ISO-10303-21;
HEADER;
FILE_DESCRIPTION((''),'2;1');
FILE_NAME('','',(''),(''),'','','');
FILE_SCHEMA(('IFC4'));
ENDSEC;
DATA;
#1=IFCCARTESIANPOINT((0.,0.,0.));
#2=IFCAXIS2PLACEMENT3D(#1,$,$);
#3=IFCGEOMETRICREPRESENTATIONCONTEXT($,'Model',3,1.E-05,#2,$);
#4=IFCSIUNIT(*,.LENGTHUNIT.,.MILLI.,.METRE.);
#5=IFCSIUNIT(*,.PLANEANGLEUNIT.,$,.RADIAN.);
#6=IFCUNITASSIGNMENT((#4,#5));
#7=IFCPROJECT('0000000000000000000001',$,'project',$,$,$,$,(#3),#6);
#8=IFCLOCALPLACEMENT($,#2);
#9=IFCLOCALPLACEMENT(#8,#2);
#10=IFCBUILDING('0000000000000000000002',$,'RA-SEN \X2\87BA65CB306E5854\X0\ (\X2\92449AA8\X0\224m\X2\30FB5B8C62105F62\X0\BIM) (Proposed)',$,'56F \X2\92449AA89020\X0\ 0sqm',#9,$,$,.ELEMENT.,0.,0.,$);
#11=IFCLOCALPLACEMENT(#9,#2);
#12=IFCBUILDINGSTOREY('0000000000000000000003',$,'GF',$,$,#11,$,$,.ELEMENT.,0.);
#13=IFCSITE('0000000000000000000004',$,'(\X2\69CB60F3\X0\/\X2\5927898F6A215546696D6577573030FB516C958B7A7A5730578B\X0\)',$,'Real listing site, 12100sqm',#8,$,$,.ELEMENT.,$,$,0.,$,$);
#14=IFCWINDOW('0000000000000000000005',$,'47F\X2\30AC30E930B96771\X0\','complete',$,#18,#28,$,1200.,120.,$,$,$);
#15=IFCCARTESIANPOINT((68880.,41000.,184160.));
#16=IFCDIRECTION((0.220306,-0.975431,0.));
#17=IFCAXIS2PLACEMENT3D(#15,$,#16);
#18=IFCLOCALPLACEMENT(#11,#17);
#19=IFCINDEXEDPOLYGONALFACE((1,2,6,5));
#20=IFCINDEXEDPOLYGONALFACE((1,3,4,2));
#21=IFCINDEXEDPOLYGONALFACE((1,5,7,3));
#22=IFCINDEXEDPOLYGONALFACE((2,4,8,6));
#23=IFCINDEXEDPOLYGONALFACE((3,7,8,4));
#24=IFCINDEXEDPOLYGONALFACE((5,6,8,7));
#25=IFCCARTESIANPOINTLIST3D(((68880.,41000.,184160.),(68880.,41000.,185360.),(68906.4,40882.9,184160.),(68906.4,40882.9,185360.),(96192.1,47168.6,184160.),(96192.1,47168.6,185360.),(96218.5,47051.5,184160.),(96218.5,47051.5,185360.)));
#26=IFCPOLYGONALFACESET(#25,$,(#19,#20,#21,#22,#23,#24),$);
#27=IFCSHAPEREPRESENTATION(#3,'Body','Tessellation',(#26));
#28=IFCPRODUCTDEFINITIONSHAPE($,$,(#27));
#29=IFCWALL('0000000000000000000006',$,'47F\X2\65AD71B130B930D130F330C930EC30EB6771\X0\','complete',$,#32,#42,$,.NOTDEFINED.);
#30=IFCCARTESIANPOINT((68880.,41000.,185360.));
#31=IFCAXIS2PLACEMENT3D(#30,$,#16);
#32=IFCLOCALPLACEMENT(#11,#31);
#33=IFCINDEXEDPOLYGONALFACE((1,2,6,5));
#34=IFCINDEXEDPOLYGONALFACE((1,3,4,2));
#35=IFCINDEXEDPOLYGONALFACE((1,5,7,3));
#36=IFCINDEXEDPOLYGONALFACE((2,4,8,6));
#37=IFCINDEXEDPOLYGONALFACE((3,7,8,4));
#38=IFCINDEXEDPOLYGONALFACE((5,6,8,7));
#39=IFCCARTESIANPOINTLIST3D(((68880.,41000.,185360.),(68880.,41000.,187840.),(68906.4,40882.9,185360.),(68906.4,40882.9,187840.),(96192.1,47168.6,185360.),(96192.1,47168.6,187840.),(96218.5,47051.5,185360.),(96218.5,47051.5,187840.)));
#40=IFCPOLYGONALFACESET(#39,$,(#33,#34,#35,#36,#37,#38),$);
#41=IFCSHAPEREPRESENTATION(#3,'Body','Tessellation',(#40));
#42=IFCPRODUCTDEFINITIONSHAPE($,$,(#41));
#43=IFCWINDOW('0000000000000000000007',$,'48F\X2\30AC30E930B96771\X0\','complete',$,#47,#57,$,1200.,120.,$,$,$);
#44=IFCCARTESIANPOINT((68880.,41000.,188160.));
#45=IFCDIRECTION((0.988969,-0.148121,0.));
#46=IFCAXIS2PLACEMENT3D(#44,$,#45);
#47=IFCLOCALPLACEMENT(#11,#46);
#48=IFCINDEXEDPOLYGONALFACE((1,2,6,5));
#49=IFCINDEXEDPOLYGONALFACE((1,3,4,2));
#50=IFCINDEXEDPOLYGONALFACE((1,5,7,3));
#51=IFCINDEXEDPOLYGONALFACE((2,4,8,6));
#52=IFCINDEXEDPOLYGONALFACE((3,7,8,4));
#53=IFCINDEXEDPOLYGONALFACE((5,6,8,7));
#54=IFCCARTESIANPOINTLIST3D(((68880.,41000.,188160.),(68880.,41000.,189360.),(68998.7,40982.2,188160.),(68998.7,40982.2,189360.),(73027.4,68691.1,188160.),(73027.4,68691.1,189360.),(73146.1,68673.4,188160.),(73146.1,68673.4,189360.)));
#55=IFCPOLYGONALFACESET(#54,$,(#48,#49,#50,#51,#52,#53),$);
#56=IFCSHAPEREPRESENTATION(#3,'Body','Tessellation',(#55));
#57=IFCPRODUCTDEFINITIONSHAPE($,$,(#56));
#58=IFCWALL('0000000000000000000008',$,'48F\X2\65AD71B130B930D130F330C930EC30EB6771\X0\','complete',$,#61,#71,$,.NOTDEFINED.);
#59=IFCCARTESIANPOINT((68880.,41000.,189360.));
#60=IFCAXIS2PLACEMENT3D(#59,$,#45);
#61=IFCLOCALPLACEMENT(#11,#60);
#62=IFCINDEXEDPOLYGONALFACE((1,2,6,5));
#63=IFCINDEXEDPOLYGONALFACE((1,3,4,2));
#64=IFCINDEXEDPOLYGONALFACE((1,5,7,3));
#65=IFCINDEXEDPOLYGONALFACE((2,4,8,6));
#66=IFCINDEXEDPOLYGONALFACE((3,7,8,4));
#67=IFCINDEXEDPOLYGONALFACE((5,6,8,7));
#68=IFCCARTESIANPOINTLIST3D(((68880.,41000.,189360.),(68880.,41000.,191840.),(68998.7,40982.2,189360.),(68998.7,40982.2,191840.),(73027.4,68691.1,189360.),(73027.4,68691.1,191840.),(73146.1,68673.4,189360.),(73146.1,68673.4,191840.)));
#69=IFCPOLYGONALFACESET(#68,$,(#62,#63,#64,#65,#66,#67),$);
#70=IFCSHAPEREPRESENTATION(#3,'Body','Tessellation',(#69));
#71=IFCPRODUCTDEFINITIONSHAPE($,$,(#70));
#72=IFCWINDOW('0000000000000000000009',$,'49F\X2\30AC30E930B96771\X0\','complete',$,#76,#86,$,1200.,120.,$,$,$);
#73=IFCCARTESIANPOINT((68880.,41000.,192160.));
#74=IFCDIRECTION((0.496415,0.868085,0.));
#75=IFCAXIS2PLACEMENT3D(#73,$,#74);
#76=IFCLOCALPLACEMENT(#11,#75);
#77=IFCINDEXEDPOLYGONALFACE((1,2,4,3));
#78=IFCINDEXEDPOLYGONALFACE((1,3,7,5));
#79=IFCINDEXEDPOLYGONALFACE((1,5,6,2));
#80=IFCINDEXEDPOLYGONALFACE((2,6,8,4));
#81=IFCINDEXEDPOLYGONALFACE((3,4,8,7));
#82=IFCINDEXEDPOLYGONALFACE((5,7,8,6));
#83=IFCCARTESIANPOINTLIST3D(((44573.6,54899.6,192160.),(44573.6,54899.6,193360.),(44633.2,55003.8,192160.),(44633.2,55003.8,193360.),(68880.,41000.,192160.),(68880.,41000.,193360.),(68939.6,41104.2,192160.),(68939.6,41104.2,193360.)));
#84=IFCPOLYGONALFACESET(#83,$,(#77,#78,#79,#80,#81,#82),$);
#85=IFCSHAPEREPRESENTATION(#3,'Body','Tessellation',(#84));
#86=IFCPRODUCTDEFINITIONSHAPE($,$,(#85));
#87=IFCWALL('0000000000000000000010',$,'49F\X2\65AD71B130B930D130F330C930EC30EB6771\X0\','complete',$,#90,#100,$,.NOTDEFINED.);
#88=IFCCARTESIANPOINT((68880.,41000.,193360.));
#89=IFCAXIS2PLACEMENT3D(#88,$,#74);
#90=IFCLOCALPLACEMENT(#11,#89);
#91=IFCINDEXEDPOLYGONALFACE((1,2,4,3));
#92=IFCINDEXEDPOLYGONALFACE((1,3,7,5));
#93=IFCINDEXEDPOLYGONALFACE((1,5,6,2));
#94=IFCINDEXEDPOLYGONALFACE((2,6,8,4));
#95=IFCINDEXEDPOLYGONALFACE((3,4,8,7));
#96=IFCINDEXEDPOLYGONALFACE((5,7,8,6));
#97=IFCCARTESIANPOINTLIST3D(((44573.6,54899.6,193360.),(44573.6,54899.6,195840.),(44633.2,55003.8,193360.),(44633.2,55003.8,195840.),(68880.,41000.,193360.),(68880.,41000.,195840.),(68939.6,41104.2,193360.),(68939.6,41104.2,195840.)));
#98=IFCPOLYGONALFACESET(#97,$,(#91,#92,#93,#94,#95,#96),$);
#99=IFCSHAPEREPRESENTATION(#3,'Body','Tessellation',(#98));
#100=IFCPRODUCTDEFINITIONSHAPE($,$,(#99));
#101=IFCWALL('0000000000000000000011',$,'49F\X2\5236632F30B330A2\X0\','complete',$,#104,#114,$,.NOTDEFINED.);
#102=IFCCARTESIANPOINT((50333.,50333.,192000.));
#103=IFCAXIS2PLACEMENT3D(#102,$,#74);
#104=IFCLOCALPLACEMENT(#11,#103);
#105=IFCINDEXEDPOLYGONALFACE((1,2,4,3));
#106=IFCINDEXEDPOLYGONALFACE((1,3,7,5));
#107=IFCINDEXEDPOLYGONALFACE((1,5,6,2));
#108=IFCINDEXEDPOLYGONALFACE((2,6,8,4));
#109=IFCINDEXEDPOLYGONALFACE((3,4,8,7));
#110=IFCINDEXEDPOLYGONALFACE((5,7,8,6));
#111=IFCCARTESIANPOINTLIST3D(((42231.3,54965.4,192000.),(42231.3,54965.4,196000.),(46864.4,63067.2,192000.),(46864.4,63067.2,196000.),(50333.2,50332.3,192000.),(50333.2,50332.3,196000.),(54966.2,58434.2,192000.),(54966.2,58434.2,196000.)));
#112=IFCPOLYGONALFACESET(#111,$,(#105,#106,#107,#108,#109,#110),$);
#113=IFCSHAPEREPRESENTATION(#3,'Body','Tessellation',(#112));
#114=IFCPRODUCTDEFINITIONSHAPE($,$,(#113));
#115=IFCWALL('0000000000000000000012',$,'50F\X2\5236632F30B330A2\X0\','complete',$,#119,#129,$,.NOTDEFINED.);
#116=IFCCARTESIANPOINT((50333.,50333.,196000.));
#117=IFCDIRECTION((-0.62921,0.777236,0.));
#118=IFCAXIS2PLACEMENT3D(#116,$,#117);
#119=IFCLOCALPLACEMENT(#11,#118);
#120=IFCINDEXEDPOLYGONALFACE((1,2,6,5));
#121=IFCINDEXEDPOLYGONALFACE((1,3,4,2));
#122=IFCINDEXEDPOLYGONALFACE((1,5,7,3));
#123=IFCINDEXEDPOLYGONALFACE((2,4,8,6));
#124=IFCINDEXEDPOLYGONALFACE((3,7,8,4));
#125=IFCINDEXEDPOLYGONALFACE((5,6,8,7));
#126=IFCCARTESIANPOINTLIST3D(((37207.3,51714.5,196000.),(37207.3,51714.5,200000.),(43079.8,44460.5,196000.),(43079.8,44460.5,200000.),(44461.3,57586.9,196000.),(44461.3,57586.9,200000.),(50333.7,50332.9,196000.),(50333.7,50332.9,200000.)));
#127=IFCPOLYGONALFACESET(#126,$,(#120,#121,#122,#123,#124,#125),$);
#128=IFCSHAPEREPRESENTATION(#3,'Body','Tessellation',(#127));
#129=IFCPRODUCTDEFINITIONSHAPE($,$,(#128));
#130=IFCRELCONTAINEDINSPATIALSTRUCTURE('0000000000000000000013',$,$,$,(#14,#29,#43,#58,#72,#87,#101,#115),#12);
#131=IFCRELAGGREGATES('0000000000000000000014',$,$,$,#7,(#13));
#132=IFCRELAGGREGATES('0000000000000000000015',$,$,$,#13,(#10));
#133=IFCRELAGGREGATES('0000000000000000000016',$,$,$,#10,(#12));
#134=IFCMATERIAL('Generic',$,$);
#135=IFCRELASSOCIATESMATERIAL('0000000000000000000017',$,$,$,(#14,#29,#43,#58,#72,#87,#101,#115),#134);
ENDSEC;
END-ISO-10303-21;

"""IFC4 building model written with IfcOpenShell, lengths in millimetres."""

from ifc_helpers import new_model, si_unit, frame, frame_2d, origin, place, context, project, spatial, rectangle, extrude, material, element, save


model = new_model("IFC4")

# Units and contexts
model_context = context("Model", 3, precision=1e-05, world=origin())
ifc_project = project(units=[si_unit("LENGTHUNIT", "METRE", prefix="MILLI"), si_unit("PLANEANGLEUNIT", "RADIAN")], contexts=[model_context])

# Site, building, storey
site_placement = place(None, origin())
site = spatial("IfcSite", under=ifc_project, at=site_placement, Name="(構想/大規模商業敷地・公開空地型)", ObjectType="Real listing site, 12100sqm", CompositionType="ELEMENT", RefElevation=0.0)
building_placement = place(site_placement, origin())
building = spatial("IfcBuilding", under=site, at=building_placement, Name="RA-SEN 螺旋の塔 (鉄骨224m・完成形BIM) (Proposed)", ObjectType="56F 鉄骨造 0sqm", CompositionType="ELEMENT", ElevationOfRefHeight=0.0, ElevationOfTerrain=0.0)
storey_placement = place(building_placement, origin())
storey = spatial("IfcBuildingStorey", under=building, at=storey_placement, Name="GF", CompositionType="ELEMENT", Elevation=0.0)

# Shared definitions
ifc_material = material(Name="Generic")

# Window
window_1_placement = place(storey_placement, frame((68880.0, 41000.0, 184160.0), x_axis=(0.220306, -0.975431, 0.0)))
element("IfcWindow", 1, at=window_1_placement, inside=storey, material=ifc_material, Name="47Fガラス東", Description="complete", OverallHeight=1200.0, OverallWidth=120.0, context=model_context, shape_type="SweptSolid", body=[
    extrude(rectangle(XDim=120.0, YDim=28000.0, at=frame_2d((60.0, 14000.0))), frame((68880.0, 41000.0, 184160.0), x_axis=(0.220306, -0.975431, 0.0)), (0.0, 0.0, 1.0), 1200.0),
])

# Wall
wall_1_placement = place(storey_placement, frame((68880.0, 41000.0, 185360.0), x_axis=(0.220306, -0.975431, 0.0)))
element("IfcWall", 2, at=wall_1_placement, inside=storey, material=ifc_material, Name="47F断熱スパンドレル東", Description="complete", PredefinedType="NOTDEFINED", context=model_context, shape_type="SweptSolid", body=[
    extrude(rectangle(XDim=120.0, YDim=28000.0, at=frame_2d((60.0, 14000.0))), frame((68880.0, 41000.0, 185360.0), x_axis=(0.220306, -0.975431, 0.0)), (0.0, 0.0, 1.0), 2480.0),
])

# Window
window_2_placement = place(storey_placement, frame((68880.0, 41000.0, 188160.0), x_axis=(0.988969, -0.148121, 0.0)))
element("IfcWindow", 3, at=window_2_placement, inside=storey, material=ifc_material, Name="48Fガラス東", Description="complete", OverallHeight=1200.0, OverallWidth=120.0, context=model_context, shape_type="SweptSolid", body=[
    extrude(rectangle(XDim=120.0, YDim=28000.0, at=frame_2d((60.0, 14000.0))), frame((68880.0, 41000.0, 188160.0), x_axis=(0.988969, -0.148121, 0.0)), (0.0, 0.0, 1.0), 1200.0),
])

# Wall
wall_2_placement = place(storey_placement, frame((68880.0, 41000.0, 189360.0), x_axis=(0.988969, -0.148121, 0.0)))
element("IfcWall", 4, at=wall_2_placement, inside=storey, material=ifc_material, Name="48F断熱スパンドレル東", Description="complete", PredefinedType="NOTDEFINED", context=model_context, shape_type="SweptSolid", body=[
    extrude(rectangle(XDim=120.0, YDim=28000.0, at=frame_2d((60.0, 14000.0))), frame((68880.0, 41000.0, 189360.0), x_axis=(0.988969, -0.148121, 0.0)), (0.0, 0.0, 1.0), 2480.0),
])

# Window
window_3_placement = place(storey_placement, frame((68880.0, 41000.0, 192160.0), x_axis=(0.496415, 0.868085, 0.0)))
element("IfcWindow", 5, at=window_3_placement, inside=storey, material=ifc_material, Name="49Fガラス東", Description="complete", OverallHeight=1200.0, OverallWidth=120.0, context=model_context, shape_type="SweptSolid", body=[
    extrude(rectangle(XDim=120.0, YDim=28000.0, at=frame_2d((60.0, 14000.0))), frame((68880.0, 41000.0, 192160.0), x_axis=(0.496415, 0.868085, 0.0)), (0.0, 0.0, 1.0), 1200.0),
])

# Walls
wall_3_placement = place(storey_placement, frame((68880.0, 41000.0, 193360.0), x_axis=(0.496415, 0.868085, 0.0)))
element("IfcWall", 6, at=wall_3_placement, inside=storey, material=ifc_material, Name="49F断熱スパンドレル東", Description="complete", PredefinedType="NOTDEFINED", context=model_context, shape_type="SweptSolid", body=[
    extrude(rectangle(XDim=120.0, YDim=28000.0, at=frame_2d((60.0, 14000.0))), frame((68880.0, 41000.0, 193360.0), x_axis=(0.496415, 0.868085, 0.0)), (0.0, 0.0, 1.0), 2480.0),
])
wall_4_placement = place(storey_placement, frame((50333.0, 50333.0, 192000.0), x_axis=(0.496415, 0.868085, 0.0)))
element("IfcWall", 7, at=wall_4_placement, inside=storey, material=ifc_material, Name="49F制振コア", Description="complete", PredefinedType="NOTDEFINED", context=model_context, shape_type="SweptSolid", body=[
    extrude(rectangle(XDim=9333.0, YDim=9333.0, at=frame_2d((4666.0, 4666.0))), frame((50333.0, 50333.0, 192000.0), x_axis=(0.496415, 0.868085, 0.0)), (0.0, 0.0, 1.0), 4000.0),
])
wall_5_placement = place(storey_placement, frame((50333.0, 50333.0, 196000.0), x_axis=(-0.62921, 0.777236, 0.0)))
element("IfcWall", 8, at=wall_5_placement, inside=storey, material=ifc_material, Name="50F制振コア", Description="complete", PredefinedType="NOTDEFINED", context=model_context, shape_type="SweptSolid", body=[
    extrude(rectangle(XDim=9333.0, YDim=9333.0, at=frame_2d((4666.0, 4666.0))), frame((50333.0, 50333.0, 196000.0), x_axis=(-0.62921, 0.777236, 0.0)), (0.0, 0.0, 1.0), 4000.0),
])

save(model, "model.ifc")
